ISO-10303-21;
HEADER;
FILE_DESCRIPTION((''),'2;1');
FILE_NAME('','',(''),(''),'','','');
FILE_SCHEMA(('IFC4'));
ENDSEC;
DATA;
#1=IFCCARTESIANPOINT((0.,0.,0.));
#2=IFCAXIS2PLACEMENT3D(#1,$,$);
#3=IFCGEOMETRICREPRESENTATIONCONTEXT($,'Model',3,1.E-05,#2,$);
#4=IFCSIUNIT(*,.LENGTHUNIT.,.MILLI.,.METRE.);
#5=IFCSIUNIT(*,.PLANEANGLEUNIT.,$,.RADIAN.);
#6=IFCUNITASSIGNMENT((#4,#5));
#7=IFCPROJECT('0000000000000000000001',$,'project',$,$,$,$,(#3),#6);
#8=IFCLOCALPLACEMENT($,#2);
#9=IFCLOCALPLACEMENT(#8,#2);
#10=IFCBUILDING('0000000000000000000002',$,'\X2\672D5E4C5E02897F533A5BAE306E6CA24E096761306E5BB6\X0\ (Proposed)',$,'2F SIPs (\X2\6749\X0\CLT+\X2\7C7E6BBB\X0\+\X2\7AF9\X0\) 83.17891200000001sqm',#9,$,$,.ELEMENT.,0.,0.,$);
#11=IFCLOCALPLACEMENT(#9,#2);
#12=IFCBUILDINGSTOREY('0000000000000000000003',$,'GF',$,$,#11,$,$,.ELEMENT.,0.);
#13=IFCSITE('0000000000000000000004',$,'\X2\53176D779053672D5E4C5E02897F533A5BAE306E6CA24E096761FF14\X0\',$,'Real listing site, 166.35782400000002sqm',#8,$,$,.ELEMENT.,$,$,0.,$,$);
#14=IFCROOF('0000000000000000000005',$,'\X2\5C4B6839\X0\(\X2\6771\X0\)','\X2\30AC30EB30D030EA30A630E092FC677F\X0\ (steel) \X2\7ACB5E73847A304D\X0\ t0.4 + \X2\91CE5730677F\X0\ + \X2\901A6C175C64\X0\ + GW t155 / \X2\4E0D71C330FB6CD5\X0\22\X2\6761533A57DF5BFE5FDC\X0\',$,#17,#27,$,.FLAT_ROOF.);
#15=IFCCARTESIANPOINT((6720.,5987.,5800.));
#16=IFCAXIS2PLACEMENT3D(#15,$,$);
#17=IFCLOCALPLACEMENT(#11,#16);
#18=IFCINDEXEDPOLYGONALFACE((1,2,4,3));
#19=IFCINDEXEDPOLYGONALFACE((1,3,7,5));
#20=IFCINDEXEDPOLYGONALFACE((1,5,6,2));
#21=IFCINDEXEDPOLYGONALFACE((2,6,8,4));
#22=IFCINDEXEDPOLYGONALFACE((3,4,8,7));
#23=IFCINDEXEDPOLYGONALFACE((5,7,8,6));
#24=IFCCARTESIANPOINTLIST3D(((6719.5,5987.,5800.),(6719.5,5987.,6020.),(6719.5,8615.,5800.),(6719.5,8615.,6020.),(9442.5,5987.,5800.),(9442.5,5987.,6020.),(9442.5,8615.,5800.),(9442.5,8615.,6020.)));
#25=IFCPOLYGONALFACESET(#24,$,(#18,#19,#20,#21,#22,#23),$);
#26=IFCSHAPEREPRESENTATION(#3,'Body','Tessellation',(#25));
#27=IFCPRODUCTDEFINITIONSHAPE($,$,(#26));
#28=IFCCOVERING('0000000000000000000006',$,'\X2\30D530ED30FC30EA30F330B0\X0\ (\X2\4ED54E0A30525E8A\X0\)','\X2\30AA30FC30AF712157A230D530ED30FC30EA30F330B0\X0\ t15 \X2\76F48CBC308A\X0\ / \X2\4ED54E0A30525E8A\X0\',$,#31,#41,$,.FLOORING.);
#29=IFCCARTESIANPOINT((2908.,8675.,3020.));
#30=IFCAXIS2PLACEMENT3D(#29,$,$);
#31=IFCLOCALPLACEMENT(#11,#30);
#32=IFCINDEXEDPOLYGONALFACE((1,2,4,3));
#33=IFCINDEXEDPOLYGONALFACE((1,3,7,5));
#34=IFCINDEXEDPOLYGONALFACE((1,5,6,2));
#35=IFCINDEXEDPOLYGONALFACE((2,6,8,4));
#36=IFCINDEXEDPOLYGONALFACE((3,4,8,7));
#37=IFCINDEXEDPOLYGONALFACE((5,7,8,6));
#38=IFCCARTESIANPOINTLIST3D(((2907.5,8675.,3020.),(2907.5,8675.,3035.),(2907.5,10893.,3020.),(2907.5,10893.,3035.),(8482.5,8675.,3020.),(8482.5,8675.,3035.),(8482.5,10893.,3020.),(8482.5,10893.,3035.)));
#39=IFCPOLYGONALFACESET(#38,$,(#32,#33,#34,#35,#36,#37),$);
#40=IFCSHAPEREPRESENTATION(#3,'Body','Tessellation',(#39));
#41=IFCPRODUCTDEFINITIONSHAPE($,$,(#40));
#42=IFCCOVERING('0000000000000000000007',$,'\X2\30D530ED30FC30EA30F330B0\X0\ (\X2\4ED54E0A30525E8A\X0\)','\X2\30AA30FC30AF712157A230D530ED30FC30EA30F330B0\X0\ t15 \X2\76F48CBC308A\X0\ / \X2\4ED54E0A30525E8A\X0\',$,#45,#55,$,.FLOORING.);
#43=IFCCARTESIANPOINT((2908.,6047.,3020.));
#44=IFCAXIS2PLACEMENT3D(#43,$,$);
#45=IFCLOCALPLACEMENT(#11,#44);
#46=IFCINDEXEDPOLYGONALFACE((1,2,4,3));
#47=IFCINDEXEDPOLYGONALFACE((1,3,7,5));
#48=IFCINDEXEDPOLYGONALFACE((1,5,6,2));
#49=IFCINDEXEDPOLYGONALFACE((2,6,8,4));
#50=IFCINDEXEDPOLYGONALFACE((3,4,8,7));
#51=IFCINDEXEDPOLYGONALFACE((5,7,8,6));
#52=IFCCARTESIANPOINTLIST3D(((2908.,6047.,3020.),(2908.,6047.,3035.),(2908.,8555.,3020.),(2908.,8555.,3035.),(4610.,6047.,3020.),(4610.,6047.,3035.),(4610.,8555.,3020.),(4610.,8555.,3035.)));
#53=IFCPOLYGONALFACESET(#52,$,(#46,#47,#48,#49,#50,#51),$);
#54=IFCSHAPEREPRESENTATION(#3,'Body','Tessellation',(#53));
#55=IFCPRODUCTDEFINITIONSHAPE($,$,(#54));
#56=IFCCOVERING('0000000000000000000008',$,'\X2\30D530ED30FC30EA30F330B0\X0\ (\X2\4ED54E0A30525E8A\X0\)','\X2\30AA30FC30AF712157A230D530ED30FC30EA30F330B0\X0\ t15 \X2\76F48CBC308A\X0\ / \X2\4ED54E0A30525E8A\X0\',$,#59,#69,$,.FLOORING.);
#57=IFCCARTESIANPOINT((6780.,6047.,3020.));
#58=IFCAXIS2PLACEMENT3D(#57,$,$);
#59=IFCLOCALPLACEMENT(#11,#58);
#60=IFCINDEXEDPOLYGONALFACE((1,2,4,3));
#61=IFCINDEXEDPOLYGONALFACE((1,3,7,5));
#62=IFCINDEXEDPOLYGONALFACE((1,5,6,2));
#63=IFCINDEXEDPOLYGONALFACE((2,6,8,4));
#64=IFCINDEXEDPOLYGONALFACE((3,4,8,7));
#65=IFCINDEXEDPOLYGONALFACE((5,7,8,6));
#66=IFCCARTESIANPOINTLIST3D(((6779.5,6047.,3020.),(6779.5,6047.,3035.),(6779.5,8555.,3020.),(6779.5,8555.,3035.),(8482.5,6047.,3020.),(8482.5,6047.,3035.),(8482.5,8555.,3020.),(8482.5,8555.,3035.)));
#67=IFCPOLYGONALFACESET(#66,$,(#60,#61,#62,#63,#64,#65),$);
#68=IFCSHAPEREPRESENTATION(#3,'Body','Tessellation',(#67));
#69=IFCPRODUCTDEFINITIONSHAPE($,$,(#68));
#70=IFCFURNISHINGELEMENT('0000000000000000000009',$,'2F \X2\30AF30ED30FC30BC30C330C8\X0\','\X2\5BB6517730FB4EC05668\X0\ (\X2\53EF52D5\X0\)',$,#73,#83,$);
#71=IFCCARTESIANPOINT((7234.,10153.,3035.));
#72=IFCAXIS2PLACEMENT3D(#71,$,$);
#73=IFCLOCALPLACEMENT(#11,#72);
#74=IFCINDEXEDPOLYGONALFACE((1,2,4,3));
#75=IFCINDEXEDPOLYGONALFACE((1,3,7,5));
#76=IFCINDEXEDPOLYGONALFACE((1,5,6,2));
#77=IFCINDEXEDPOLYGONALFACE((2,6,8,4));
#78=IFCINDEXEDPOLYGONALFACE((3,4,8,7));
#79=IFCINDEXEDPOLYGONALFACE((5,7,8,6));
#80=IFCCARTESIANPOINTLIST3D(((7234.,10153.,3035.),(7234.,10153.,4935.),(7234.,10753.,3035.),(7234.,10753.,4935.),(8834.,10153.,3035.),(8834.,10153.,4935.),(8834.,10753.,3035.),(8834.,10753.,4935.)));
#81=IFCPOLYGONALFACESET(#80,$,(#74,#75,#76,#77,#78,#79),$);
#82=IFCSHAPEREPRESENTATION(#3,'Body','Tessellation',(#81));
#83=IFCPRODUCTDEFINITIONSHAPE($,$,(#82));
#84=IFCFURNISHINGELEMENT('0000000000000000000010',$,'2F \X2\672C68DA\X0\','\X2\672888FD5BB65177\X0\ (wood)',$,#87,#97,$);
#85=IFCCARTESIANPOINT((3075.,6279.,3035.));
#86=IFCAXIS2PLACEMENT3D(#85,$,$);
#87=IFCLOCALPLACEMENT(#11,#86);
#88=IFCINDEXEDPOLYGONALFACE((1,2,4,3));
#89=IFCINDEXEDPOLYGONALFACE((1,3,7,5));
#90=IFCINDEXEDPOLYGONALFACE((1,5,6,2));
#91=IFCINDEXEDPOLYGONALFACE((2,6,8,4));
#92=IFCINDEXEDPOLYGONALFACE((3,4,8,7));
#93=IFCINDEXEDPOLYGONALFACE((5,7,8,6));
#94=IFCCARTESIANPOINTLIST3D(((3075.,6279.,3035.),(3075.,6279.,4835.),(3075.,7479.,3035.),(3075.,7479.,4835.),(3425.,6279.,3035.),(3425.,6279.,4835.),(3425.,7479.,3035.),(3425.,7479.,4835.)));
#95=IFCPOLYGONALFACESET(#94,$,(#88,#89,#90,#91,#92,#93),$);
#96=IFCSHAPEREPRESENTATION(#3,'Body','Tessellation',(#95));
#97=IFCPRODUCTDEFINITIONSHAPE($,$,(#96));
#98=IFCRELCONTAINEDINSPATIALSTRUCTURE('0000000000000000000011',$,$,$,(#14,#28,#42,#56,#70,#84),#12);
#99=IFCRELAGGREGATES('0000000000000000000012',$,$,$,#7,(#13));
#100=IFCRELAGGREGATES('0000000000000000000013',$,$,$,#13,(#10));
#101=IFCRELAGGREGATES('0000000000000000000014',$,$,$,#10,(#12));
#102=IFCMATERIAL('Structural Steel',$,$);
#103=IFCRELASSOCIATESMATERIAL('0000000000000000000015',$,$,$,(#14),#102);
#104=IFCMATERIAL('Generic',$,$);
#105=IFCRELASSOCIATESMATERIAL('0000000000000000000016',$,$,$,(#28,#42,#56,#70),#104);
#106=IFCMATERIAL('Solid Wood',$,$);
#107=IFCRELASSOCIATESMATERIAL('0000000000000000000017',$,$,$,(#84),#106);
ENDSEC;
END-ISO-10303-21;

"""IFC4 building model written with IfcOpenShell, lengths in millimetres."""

from ifc_helpers import new_model, si_unit, frame, frame_2d, origin, place, context, project, spatial, rectangle, extrude, material, element, save


model = new_model("IFC4")

# Units and contexts
model_context = context("Model", 3, precision=1e-05, world=origin())
ifc_project = project(units=[si_unit("LENGTHUNIT", "METRE", prefix="MILLI"), si_unit("PLANEANGLEUNIT", "RADIAN")], contexts=[model_context])

# Site, building, storey
site_placement = place(None, origin())
site = spatial("IfcSite", under=ifc_project, at=site_placement, Name="北海道札幌市西区宮の沢三条４", ObjectType="Real listing site, 166.35782400000002sqm", CompositionType="ELEMENT", RefElevation=0.0)
building_placement = place(site_placement, origin())
building = spatial("IfcBuilding", under=site, at=building_placement, Name="札幌市西区宮の沢三条の家 (Proposed)", ObjectType="2F SIPs (杉CLT+籾殻+竹) 83.17891200000001sqm", CompositionType="ELEMENT", ElevationOfRefHeight=0.0, ElevationOfTerrain=0.0)
storey_placement = place(building_placement, origin())
storey = spatial("IfcBuildingStorey", under=building, at=storey_placement, Name="GF", CompositionType="ELEMENT", Elevation=0.0)

# Shared definitions
ifc_material_1 = material(Name="Solid Wood")

# Roof
ifc_material_2 = material(Name="Structural Steel")
roof_1_placement = place(storey_placement, frame((6720.0, 5987.0, 5800.0)))
element("IfcRoof", 1, at=roof_1_placement, inside=storey, material=ifc_material_2, Name="屋根(東)", Description="ガルバリウム鋼板 (steel) 立平葺き t0.4 + 野地板 + 通気層 + GW t155 / 不燃・法22条区域対応", PredefinedType="FLAT_ROOF", context=model_context, shape_type="SweptSolid", body=[
    extrude(rectangle(XDim=2723.0, YDim=2628.0, at=frame_2d((1361.0, 1314.0))), frame((6720.0, 5987.0, 5800.0)), (0.0, 0.0, 1.0), 220.0),
])

# Coverings
ifc_material_3 = material(Name="Generic")
covering_1_placement = place(storey_placement, frame((2908.0, 8675.0, 3020.0)))
element("IfcCovering", 2, at=covering_1_placement, inside=storey, material=ifc_material_3, Name="フローリング (仕上げ床)", Description="オーク無垢フローリング t15 直貼り / 仕上げ床", PredefinedType="FLOORING", context=model_context, shape_type="SweptSolid", body=[
    extrude(rectangle(XDim=5575.0, YDim=2218.0, at=frame_2d((2787.0, 1109.0))), frame((2908.0, 8675.0, 3020.0)), (0.0, 0.0, 1.0), 15.0),
])
covering_2_placement = place(storey_placement, frame((2908.0, 6047.0, 3020.0)))
element("IfcCovering", 3, at=covering_2_placement, inside=storey, material=ifc_material_3, Name="フローリング (仕上げ床)", Description="オーク無垢フローリング t15 直貼り / 仕上げ床", PredefinedType="FLOORING", context=model_context, shape_type="SweptSolid", body=[
    extrude(rectangle(XDim=1702.0, YDim=2508.0, at=frame_2d((851.0, 1254.0))), frame((2908.0, 6047.0, 3020.0)), (0.0, 0.0, 1.0), 15.0),
])
covering_3_placement = place(storey_placement, frame((6780.0, 6047.0, 3020.0)))
element("IfcCovering", 4, at=covering_3_placement, inside=storey, material=ifc_material_3, Name="フローリング (仕上げ床)", Description="オーク無垢フローリング t15 直貼り / 仕上げ床", PredefinedType="FLOORING", context=model_context, shape_type="SweptSolid", body=[
    extrude(rectangle(XDim=1703.0, YDim=2508.0, at=frame_2d((851.0, 1254.0))), frame((6780.0, 6047.0, 3020.0)), (0.0, 0.0, 1.0), 15.0),
])

# Furnishing elements
furnishing_1_placement = place(storey_placement, frame((7234.0, 10153.0, 3035.0)))
element("IfcFurnishingElement", 5, at=furnishing_1_placement, inside=storey, material=ifc_material_3, Name="2F クローゼット", Description="家具・什器 (可動)", context=model_context, shape_type="SweptSolid", body=[
    extrude(rectangle(XDim=1600.0, YDim=600.0, at=frame_2d((800.0, 300.0))), frame((7234.0, 10153.0, 3035.0)), (0.0, 0.0, 1.0), 1900.0),
])
furnishing_2_placement = place(storey_placement, frame((3075.0, 6279.0, 3035.0)))
element("IfcFurnishingElement", 6, at=furnishing_2_placement, inside=storey, material=ifc_material_1, Name="2F 本棚", Description="木製家具 (wood)", context=model_context, shape_type="SweptSolid", body=[
    extrude(rectangle(XDim=350.0, YDim=1200.0, at=frame_2d((175.0, 600.0))), frame((3075.0, 6279.0, 3035.0)), (0.0, 0.0, 1.0), 1800.0),
])

save(model, "model.ifc")
